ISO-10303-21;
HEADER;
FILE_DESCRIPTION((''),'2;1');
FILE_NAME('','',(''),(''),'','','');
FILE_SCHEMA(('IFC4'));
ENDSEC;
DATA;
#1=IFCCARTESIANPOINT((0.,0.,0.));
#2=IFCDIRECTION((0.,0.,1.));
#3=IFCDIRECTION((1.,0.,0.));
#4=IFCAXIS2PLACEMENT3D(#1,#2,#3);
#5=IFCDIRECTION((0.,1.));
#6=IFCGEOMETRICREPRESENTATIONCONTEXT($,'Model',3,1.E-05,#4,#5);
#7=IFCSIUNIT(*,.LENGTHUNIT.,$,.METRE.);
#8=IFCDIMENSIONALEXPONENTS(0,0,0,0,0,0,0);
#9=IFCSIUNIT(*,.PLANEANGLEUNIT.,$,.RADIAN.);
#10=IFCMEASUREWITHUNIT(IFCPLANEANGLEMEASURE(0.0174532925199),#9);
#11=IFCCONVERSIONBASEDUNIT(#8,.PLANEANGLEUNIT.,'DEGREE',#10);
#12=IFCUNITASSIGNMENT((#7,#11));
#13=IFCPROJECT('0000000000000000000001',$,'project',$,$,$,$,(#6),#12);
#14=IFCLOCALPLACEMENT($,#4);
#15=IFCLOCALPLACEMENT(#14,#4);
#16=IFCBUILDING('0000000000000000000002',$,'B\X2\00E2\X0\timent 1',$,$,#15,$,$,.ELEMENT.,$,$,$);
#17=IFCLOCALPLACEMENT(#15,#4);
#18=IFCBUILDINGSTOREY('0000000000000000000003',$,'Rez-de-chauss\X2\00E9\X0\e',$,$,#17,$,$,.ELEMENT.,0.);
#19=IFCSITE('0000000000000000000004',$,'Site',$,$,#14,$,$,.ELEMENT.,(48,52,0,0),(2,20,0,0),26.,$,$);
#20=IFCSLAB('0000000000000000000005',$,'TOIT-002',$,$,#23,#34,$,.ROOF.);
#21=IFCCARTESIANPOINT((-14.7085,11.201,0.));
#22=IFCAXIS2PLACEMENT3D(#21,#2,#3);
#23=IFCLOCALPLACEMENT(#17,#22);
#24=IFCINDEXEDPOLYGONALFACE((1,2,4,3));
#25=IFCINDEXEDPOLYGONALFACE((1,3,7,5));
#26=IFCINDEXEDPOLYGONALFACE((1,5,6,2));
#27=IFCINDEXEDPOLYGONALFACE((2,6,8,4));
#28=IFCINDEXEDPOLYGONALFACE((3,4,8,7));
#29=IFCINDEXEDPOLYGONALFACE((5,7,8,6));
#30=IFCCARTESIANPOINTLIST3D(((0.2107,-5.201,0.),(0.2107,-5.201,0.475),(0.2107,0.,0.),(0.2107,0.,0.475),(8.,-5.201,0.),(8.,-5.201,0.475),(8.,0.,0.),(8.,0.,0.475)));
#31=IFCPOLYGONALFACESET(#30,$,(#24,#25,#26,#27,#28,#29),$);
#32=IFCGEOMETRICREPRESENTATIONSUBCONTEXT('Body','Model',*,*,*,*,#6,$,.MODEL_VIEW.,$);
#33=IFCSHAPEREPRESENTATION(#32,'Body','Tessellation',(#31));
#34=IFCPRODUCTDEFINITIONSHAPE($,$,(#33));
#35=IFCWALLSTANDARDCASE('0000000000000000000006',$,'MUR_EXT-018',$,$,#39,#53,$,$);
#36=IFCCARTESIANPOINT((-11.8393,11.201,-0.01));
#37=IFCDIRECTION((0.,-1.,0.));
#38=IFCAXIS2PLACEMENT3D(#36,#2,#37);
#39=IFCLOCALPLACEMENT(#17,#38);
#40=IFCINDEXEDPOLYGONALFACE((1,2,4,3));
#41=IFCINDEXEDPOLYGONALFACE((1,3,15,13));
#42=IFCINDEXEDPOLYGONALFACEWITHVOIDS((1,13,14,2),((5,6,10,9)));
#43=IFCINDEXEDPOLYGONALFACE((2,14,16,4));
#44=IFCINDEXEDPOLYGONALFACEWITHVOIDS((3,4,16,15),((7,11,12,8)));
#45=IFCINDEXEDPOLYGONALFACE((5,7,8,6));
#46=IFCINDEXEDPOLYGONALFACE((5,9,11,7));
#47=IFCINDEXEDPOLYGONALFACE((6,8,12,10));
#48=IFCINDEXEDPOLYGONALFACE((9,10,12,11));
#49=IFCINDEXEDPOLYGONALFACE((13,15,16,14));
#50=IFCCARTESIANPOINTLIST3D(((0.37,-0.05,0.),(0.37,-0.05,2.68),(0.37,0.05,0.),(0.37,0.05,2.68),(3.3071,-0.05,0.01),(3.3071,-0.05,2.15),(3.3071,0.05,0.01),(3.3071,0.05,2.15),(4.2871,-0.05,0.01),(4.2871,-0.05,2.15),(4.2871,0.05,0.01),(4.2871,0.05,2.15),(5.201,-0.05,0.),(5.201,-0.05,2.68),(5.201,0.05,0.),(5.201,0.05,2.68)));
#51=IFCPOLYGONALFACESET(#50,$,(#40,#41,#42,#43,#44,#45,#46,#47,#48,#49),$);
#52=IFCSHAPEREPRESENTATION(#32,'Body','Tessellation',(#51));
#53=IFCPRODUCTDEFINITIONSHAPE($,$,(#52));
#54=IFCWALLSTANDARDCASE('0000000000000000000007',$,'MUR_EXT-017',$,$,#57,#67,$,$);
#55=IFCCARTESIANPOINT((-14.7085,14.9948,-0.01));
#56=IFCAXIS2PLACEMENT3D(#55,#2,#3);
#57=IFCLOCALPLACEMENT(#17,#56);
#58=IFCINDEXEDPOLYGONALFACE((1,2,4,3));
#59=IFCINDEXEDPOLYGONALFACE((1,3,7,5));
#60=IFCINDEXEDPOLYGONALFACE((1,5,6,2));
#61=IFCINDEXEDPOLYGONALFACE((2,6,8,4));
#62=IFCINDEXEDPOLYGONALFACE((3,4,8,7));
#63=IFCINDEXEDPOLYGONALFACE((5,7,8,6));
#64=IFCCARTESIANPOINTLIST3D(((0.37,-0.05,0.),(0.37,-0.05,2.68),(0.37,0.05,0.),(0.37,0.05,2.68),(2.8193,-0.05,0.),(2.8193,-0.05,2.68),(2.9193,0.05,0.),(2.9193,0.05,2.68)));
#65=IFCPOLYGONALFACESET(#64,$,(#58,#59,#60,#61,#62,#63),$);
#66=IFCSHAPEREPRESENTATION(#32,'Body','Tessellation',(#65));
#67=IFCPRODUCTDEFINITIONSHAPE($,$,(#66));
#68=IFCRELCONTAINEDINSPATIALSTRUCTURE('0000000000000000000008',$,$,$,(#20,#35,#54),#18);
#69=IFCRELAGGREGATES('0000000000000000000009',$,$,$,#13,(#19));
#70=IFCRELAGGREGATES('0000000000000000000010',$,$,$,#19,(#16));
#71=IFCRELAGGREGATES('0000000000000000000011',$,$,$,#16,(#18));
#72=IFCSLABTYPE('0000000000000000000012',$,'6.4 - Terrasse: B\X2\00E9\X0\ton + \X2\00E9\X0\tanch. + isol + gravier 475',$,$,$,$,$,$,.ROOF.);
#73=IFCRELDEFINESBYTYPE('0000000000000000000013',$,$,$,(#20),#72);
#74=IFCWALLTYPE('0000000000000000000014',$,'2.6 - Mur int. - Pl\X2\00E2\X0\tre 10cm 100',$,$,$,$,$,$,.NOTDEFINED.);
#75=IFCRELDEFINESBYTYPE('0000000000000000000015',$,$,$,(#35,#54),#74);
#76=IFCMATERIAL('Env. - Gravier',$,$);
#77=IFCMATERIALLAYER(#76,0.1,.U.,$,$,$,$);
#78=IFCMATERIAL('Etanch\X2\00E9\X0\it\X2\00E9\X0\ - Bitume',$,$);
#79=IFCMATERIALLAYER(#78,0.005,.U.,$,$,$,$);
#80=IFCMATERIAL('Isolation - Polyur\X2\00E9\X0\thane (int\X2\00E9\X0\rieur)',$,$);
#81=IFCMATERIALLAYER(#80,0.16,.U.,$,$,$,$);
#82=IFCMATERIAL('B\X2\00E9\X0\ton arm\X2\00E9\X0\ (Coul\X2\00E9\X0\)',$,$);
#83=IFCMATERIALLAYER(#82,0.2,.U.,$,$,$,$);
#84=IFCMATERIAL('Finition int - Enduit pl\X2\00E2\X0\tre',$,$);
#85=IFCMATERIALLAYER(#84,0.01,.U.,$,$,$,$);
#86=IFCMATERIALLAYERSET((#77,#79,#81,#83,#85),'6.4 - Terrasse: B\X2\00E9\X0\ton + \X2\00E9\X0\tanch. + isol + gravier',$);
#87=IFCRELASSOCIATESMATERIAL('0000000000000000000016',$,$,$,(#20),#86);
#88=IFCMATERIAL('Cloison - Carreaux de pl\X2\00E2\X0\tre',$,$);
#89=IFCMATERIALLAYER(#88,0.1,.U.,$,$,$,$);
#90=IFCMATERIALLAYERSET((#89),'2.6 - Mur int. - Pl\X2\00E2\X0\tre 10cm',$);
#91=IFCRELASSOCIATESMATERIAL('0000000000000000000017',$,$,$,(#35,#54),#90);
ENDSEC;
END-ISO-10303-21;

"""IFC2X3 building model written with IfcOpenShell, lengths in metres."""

from ifc_helpers import new_model, entity, si_unit, converted_unit, direction, frame, origin_with_axes, origin_2d_with_axis, place, context, subcontext, project, spatial, polyline, rectangle, outline, extrude, material, layer, layer_set, layer_usage, type_object, element, save


model = new_model("IFC2X3")

# Units and contexts
model_context = context("Model", 3, precision=1e-05, world=origin_with_axes(), true_north=direction((0.0, 1.0)))
body_context = subcontext(model_context, "Body", "Model", "MODEL_VIEW")
ifc_project = project(units=[si_unit("LENGTHUNIT", "METRE"), converted_unit("PLANEANGLEUNIT", "DEGREE", entity("IfcPlaneAngleMeasure", 0.0174532925199), si_unit("PLANEANGLEUNIT", "RADIAN"), dimensions=[0, 0, 0, 0, 0, 0, 0])], contexts=[model_context])

# Site, building, storey
site_placement = place(None, origin_with_axes())
site = spatial("IfcSite", under=ifc_project, at=site_placement, Name="Site", CompositionType="ELEMENT", RefLatitude=(48, 52, 0, 0), RefLongitude=(2, 20, 0, 0), RefElevation=26.0)
building_placement = place(site_placement, origin_with_axes())
building = spatial("IfcBuilding", under=site, at=building_placement, Name="Bâtiment 1", CompositionType="ELEMENT")
storey_placement = place(building_placement, origin_with_axes())
storey = spatial("IfcBuildingStorey", under=building, at=storey_placement, Name="Rez-de-chaussée", CompositionType="ELEMENT", Elevation=0.0)

# Slab
ifc_material_1 = material(Name="Béton armé (Coulé)")
ifc_material_2 = material(Name="Env. - Gravier")
ifc_layer_1 = layer(ifc_material_2, 0.1, ventilated="UNKNOWN")
ifc_material_3 = material(Name="Etanchéité - Bitume")
ifc_layer_2 = layer(ifc_material_3, 0.005, ventilated="UNKNOWN")
ifc_material_4 = material(Name="Isolation - Polyuréthane (intérieur)")
ifc_layer_3 = layer(ifc_material_4, 0.16, ventilated="UNKNOWN")
ifc_layer_4 = layer(ifc_material_1, 0.2, ventilated="UNKNOWN")
ifc_material_5 = material(Name="Finition int - Enduit plâtre")
ifc_layer_5 = layer(ifc_material_5, 0.01, ventilated="UNKNOWN")
ifc_layer_set_1 = layer_set([ifc_layer_1, ifc_layer_2, ifc_layer_3, ifc_layer_4, ifc_layer_5], Name="6.4 - Terrasse: Béton + étanch. + isol + gravier")
ifc_layer_usage_1 = layer_usage(ifc_layer_set_1, "AXIS3", "NEGATIVE", 0.475)
slab_type_1 = type_object("IfcSlabType", Name="6.4 - Terrasse: Béton + étanch. + isol + gravier 475", PredefinedType="ROOF")
slab_1_placement = place(storey_placement, frame((-14.7085, 11.201, 0.0), z_axis=(0.0, 0.0, 1.0), x_axis=(1.0, 0.0, 0.0)))
element("IfcSlab", 1, at=slab_1_placement, inside=storey, type_object=slab_type_1, material=ifc_layer_usage_1, Name="TOIT-002", PredefinedType="ROOF", context=body_context, shape_type="SweptSolid", body=[
    extrude(outline(polyline([(0.2107, 0.0), (0.2107, -5.201), (8.0, -5.201), (8.0, 0.0), (0.2107, 0.0)])), origin_with_axes(), (0.0, 0.0, 1.0), 0.475),
])

# Wall, opening
ifc_material_6 = material(Name="Cloison - Carreaux de plâtre")
ifc_layer_6 = layer(ifc_material_6, 0.1, ventilated="UNKNOWN")
ifc_layer_set_2 = layer_set([ifc_layer_6], Name="2.6 - Mur int. - Plâtre 10cm")
ifc_layer_usage_2 = layer_usage(ifc_layer_set_2, "AXIS2", "POSITIVE", -0.05)
wall_type_1 = type_object("IfcWallType", Name="2.6 - Mur int. - Plâtre 10cm 100", PredefinedType="NOTDEFINED")
wall_1_placement = place(storey_placement, frame((-11.8393, 11.201, -0.01), z_axis=(0.0, 0.0, 1.0), x_axis=(0.0, -1.0, 0.0)))
wall_1 = element("IfcWallStandardCase", 2, at=wall_1_placement, inside=storey, type_object=wall_type_1, material=ifc_layer_usage_2, Name="MUR_EXT-018", context=body_context, shape_type="SweptSolid", body=[
    extrude(outline(polyline([(0.37, -0.05), (5.201, -0.05), (5.201, 0.05), (0.37, 0.05), (0.37, -0.05)])), origin_with_axes(), (0.0, 0.0, 1.0), 2.68),
])
opening_1_placement = place(wall_1_placement, frame((3.7971, 0.0, 0.01), z_axis=(0.0, 0.0, 1.0), x_axis=(1.0, 0.0, 0.0)))
element("IfcOpeningElement", 3, at=opening_1_placement, cuts=wall_1, context=body_context, shape_type="SweptSolid", body=[
    extrude(rectangle(XDim=0.98, YDim=2.14, at=origin_2d_with_axis()), frame((0.0, -0.1, 1.07), z_axis=(0.0, -1.0, 0.0), x_axis=(-1.0, 0.0, 0.0)), (0.0, 0.0, -1.0), 0.3),
])

# Wall
ifc_layer_usage_3 = layer_usage(ifc_layer_set_2, "AXIS2", "POSITIVE", -0.05)
wall_2_placement = place(storey_placement, frame((-14.7085, 14.9948, -0.01), z_axis=(0.0, 0.0, 1.0), x_axis=(1.0, 0.0, 0.0)))
element("IfcWallStandardCase", 4, at=wall_2_placement, inside=storey, type_object=wall_type_1, material=ifc_layer_usage_3, Name="MUR_EXT-017", context=body_context, shape_type="SweptSolid", body=[
    extrude(outline(polyline([(0.37, -0.05), (2.8193, -0.05), (2.9193, 0.05), (0.37, 0.05), (0.37, -0.05)])), origin_with_axes(), (0.0, 0.0, 1.0), 2.68),
])

save(model, "model.ifc")
